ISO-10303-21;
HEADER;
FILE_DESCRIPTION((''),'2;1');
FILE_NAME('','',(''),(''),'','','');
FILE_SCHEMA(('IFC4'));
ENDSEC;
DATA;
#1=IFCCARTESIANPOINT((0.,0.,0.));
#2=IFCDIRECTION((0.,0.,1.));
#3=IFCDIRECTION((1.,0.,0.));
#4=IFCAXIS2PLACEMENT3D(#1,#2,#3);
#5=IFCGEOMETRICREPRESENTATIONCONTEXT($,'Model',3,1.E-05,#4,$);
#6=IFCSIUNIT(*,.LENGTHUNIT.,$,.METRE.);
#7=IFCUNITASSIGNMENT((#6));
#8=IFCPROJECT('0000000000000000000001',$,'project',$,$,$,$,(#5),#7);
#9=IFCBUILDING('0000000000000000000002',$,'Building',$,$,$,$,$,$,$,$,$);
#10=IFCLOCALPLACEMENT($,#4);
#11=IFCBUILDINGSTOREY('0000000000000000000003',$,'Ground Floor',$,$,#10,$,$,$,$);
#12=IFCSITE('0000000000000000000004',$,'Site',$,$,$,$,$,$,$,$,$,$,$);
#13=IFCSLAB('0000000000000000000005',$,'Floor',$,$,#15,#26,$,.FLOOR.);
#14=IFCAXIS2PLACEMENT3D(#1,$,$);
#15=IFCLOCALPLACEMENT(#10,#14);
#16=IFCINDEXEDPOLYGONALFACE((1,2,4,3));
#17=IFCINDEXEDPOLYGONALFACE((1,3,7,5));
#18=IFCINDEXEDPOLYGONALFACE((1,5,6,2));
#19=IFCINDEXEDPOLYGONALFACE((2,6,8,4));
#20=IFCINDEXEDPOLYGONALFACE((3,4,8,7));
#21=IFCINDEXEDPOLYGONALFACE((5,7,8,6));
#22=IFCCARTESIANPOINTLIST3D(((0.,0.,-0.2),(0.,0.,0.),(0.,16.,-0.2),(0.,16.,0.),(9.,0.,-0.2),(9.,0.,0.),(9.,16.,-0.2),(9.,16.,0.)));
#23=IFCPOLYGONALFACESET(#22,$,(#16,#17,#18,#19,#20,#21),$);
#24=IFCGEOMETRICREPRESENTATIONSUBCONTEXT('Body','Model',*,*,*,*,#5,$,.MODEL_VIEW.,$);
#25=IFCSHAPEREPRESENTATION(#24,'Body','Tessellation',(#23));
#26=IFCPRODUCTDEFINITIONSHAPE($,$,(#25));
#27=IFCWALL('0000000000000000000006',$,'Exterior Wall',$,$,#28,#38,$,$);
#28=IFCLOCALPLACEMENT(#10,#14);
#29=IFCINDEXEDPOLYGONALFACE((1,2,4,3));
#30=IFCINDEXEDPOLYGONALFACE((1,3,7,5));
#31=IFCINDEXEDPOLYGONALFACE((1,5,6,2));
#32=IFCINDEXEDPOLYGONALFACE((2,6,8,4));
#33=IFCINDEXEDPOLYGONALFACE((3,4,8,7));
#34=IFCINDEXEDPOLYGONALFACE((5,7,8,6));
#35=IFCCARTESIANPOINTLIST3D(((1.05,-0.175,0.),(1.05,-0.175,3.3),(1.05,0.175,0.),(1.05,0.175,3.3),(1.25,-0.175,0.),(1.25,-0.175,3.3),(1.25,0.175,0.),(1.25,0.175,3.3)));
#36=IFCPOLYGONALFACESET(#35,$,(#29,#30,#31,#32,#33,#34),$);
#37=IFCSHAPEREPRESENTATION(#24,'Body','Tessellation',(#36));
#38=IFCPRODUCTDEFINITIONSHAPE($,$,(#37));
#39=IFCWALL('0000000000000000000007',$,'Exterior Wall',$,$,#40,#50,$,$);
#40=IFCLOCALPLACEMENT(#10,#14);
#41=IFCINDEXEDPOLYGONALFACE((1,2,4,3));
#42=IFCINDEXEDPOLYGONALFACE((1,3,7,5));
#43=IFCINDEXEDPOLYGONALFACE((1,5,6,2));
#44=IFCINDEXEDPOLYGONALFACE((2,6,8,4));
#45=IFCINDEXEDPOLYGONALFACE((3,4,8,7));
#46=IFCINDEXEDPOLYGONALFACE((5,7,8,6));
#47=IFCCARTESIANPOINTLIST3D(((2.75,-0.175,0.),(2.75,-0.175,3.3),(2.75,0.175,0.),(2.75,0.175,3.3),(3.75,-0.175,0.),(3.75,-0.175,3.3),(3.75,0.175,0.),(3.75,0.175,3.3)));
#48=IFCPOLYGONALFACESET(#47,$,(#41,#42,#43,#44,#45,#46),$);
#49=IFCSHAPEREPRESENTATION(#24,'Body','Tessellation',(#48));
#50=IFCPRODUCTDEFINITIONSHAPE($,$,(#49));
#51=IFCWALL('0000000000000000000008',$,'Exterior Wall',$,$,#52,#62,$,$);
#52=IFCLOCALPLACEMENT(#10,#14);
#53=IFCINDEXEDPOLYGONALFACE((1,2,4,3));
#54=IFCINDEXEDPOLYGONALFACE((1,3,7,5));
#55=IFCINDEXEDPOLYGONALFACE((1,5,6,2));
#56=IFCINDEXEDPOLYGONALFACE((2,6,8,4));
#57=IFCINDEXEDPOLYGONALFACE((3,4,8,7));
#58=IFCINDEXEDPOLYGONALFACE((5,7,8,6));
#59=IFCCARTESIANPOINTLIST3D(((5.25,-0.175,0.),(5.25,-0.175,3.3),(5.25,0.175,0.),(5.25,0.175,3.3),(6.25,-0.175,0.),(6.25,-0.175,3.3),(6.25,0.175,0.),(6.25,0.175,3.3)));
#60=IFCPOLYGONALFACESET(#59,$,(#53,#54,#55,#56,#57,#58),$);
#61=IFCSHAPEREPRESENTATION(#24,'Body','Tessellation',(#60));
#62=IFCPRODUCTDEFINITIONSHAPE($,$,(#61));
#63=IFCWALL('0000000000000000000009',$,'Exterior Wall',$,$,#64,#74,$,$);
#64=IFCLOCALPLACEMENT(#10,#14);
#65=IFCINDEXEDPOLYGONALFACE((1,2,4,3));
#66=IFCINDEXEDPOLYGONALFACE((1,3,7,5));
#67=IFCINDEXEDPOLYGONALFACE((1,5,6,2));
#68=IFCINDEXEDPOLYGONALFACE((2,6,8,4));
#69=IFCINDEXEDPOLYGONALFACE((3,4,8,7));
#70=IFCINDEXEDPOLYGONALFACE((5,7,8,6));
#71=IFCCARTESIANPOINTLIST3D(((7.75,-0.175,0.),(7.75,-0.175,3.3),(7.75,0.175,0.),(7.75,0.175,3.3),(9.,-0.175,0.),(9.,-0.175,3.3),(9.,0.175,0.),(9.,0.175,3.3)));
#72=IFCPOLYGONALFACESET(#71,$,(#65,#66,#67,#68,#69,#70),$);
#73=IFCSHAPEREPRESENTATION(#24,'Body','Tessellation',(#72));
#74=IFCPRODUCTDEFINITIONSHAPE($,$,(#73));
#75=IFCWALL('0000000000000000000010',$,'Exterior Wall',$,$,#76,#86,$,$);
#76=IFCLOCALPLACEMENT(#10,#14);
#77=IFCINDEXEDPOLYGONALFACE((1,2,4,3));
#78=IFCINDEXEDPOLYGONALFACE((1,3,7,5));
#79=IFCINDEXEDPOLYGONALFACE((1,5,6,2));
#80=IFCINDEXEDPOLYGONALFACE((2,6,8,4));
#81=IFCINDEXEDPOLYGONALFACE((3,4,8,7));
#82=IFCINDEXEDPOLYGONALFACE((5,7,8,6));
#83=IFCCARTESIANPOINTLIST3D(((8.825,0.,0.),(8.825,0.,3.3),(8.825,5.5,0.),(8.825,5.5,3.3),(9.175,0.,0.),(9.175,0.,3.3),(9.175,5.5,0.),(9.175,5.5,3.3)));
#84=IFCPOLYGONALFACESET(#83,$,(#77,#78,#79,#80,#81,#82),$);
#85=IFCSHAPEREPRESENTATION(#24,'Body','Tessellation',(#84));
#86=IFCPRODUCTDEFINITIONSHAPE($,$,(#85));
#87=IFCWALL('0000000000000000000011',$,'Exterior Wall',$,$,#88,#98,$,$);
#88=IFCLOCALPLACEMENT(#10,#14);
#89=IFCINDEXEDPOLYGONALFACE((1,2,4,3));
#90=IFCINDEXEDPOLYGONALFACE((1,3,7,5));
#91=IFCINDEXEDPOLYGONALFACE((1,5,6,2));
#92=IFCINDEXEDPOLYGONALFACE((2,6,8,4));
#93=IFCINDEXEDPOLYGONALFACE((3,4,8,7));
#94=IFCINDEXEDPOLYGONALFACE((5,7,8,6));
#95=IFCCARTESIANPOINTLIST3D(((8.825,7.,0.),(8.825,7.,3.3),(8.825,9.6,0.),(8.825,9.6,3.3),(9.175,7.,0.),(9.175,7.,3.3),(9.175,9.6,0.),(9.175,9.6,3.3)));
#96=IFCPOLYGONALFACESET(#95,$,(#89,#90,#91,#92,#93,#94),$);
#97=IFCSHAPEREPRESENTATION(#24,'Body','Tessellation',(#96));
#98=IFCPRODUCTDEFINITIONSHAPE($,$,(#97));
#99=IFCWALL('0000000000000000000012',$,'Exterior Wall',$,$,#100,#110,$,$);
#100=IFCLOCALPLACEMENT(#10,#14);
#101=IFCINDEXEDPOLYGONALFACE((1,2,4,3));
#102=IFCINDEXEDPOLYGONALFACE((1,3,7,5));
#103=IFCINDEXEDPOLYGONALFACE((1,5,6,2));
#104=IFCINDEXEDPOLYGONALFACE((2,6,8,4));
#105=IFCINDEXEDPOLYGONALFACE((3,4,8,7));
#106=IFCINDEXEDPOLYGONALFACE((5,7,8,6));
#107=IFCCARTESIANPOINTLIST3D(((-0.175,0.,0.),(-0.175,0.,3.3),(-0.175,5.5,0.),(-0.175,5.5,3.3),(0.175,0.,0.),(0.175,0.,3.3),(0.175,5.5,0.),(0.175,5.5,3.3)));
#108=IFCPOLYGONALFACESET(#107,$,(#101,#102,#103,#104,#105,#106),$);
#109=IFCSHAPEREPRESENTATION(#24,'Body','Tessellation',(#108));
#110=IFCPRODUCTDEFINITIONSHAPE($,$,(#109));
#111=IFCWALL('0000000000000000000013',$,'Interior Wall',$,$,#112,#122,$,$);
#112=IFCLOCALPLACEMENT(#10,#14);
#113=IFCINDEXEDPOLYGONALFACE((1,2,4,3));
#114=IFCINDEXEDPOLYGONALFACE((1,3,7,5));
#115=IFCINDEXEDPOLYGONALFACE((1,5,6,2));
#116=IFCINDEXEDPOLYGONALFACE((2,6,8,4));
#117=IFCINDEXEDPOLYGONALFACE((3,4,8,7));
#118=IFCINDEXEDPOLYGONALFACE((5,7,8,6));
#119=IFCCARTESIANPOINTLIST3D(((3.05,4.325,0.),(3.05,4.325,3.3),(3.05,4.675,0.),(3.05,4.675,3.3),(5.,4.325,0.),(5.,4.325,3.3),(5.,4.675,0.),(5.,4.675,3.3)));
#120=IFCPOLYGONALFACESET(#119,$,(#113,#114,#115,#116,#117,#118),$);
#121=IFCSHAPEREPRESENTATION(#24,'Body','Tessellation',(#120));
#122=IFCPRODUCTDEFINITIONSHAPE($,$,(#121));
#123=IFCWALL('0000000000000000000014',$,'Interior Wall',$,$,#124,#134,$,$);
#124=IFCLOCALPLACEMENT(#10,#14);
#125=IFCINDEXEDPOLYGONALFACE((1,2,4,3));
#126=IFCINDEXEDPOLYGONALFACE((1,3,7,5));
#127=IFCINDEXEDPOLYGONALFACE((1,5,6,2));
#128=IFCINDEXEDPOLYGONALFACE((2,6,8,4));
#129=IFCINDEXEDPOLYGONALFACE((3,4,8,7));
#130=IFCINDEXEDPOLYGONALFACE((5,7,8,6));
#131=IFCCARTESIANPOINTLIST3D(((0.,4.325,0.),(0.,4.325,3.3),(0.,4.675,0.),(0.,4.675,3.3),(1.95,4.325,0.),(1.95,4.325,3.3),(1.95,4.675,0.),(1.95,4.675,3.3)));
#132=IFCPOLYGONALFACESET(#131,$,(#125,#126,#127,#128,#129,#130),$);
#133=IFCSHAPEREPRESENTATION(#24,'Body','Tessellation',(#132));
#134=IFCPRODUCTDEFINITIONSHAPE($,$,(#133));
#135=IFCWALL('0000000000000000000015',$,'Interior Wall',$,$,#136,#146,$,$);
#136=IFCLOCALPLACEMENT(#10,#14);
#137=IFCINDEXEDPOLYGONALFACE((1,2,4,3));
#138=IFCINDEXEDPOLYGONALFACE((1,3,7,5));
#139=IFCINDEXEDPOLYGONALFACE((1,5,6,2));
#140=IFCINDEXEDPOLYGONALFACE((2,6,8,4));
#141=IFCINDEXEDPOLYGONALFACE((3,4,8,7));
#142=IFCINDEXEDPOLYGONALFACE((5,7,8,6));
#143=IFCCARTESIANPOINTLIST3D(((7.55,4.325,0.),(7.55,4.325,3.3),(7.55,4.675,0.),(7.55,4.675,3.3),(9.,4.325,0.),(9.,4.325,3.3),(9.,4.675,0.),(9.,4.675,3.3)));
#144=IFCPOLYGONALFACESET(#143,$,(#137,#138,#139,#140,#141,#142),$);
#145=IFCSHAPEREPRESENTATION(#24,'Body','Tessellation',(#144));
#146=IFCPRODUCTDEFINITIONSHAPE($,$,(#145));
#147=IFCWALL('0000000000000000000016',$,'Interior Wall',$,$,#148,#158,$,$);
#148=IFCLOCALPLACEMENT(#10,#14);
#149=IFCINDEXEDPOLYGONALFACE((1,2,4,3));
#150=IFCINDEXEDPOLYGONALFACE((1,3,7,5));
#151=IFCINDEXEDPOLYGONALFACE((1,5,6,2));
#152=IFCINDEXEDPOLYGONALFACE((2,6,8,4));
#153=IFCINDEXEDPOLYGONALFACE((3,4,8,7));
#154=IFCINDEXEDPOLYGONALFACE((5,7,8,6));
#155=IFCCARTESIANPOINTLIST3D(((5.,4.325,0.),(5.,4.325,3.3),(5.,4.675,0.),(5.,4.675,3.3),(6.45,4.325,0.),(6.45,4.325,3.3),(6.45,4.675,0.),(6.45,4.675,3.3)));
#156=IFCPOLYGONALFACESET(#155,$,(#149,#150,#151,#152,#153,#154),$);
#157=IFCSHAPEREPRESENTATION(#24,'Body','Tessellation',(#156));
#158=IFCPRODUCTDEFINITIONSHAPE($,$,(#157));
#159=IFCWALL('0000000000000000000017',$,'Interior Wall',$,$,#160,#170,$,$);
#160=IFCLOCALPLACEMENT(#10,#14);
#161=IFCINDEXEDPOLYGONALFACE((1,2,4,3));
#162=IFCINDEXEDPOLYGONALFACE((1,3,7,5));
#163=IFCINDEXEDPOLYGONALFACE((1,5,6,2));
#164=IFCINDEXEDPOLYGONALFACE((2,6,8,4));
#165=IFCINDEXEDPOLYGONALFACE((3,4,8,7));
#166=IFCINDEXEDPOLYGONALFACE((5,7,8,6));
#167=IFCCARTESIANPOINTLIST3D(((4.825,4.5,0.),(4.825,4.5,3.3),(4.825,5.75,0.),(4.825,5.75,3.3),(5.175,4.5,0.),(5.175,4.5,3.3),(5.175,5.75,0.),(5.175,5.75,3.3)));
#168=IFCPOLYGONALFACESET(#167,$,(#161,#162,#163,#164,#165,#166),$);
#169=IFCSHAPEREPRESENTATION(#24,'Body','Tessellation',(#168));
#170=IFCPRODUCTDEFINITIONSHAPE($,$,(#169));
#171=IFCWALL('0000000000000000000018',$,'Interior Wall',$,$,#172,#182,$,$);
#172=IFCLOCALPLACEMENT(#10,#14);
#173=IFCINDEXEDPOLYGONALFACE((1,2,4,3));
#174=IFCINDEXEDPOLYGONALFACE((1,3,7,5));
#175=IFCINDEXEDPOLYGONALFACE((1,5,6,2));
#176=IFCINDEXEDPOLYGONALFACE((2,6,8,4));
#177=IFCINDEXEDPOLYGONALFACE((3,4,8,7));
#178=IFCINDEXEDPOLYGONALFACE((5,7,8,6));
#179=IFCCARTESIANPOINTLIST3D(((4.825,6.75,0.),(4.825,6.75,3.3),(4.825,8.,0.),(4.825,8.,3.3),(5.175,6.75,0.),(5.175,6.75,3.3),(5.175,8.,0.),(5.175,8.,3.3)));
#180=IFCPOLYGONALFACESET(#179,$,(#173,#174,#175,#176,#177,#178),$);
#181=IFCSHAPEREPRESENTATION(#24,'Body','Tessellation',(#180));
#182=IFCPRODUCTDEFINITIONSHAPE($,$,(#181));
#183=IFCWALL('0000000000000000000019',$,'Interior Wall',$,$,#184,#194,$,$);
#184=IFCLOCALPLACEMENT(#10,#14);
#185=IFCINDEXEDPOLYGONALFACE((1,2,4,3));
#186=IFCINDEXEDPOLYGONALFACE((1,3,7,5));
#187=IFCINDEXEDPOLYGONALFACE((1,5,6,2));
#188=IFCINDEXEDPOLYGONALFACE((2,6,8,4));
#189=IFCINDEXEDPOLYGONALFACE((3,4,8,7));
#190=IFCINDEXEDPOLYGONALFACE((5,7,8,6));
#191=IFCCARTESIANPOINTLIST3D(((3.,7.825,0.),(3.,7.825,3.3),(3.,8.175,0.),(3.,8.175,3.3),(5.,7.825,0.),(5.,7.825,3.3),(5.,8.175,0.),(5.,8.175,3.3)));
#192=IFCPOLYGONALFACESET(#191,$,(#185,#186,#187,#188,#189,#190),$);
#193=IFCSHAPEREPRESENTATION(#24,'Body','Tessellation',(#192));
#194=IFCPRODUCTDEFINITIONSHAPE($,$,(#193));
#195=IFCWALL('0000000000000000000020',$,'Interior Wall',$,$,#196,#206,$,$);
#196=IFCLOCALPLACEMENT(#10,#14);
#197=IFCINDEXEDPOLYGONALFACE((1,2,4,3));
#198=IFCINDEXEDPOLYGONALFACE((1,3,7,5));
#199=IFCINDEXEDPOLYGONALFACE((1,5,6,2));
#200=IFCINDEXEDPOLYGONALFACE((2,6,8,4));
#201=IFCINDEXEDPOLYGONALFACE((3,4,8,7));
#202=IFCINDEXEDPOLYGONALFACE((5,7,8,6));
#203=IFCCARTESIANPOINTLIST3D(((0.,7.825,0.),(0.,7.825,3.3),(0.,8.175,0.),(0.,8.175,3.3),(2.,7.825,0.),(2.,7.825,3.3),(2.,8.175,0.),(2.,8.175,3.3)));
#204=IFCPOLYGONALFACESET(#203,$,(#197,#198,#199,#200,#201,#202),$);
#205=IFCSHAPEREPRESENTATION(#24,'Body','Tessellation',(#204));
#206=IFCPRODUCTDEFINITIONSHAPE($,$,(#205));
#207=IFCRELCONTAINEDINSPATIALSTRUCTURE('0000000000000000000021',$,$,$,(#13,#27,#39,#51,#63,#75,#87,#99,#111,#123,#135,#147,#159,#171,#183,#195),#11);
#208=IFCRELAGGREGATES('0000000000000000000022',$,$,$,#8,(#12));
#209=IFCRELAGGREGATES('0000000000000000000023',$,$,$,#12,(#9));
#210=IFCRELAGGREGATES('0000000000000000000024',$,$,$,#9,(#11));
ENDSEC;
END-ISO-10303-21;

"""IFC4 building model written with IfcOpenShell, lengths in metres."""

from ifc_helpers import new_model, si_unit, frame, origin_with_axes, place, context, subcontext, project, spatial, indexed_curve, outline, extrude, element, save


model = new_model("IFC4")

# Units and contexts
model_context = context("Model", 3, precision=1e-05, world=origin_with_axes())
body_context = subcontext(model_context, "Body", "Model", "MODEL_VIEW")
ifc_project = project(units=[si_unit("LENGTHUNIT", "METRE")], contexts=[model_context])

# Site, building, storey
site = spatial("IfcSite", under=ifc_project, Name="Site")
building = spatial("IfcBuilding", under=site, Name="Building")
storey_placement = place(None, origin_with_axes())
storey = spatial("IfcBuildingStorey", under=building, at=storey_placement, Name="Ground Floor")

# Slab
slab_placement = place(storey_placement, frame((0.0, 0.0, -0.2), z_axis=(0.0, 0.0, 1.0), x_axis=(1.0, 0.0, 0.0)))
element("IfcSlab", 1, at=slab_placement, inside=storey, Name="Floor", PredefinedType="FLOOR", context=body_context, shape_type="SweptSolid", body=[
    extrude(outline(indexed_curve([(0.0, 0.0), (9.0, 0.0), (9.0, 16.0), (0.0, 16.0)])), None, (0.0, 0.0, 1.0), 0.2),
])

# Walls
wall_1_placement = place(storey_placement, frame((1.05, 0.0, 0.0), z_axis=(0.0, 0.0, 1.0), x_axis=(1.0, 0.0, 0.0)))
element("IfcWall", 2, at=wall_1_placement, inside=storey, Name="Exterior Wall", context=body_context, shape_type="SweptSolid", body=[
    extrude(outline(indexed_curve([(0.0, 0.0), (0.0, 0.35), (0.2, 0.35), (0.2, 0.0), (0.0, 0.0)], self_intersect=False)), frame((0.0, -0.175, 0.0), z_axis=(0.0, 0.0, 1.0), x_axis=(1.0, 0.0, 0.0)), (0.0, 0.0, 1.0), 3.3),
])
for number, where, z_axis, x_axis, name in (
    (3, (2.75, 0.0, 0.0), (0.0, 0.0, 1.0), (1.0, 0.0, 0.0), "Exterior Wall"),
    (4, (5.25, 0.0, 0.0), (0.0, 0.0, 1.0), (1.0, 0.0, 0.0), "Exterior Wall"),
):
    element("IfcWall", number, at=place(storey_placement, frame(where, z_axis=z_axis, x_axis=x_axis)), inside=storey, Name=name, context=body_context, shape_type="SweptSolid", body=[
        extrude(outline(indexed_curve([(0.0, 0.0), (0.0, 0.35), (1.0, 0.35), (1.0, 0.0), (0.0, 0.0)], self_intersect=False)), frame((0.0, -0.175, 0.0), z_axis=(0.0, 0.0, 1.0), x_axis=(1.0, 0.0, 0.0)), (0.0, 0.0, 1.0), 3.3),
    ])
wall_2_placement = place(storey_placement, frame((7.75, 0.0, 0.0), z_axis=(0.0, 0.0, 1.0), x_axis=(1.0, 0.0, 0.0)))
element("IfcWall", 5, at=wall_2_placement, inside=storey, Name="Exterior Wall", context=body_context, shape_type="SweptSolid", body=[
    extrude(outline(indexed_curve([(0.0, 0.0), (0.0, 0.35), (1.25, 0.35), (1.25, 0.0), (0.0, 0.0)], self_intersect=False)), frame((0.0, -0.175, 0.0), z_axis=(0.0, 0.0, 1.0), x_axis=(1.0, 0.0, 0.0)), (0.0, 0.0, 1.0), 3.3),
])
wall_3_placement = place(storey_placement, frame((9.0, 0.0, 0.0), z_axis=(0.0, 0.0, 1.0), x_axis=(0.0, 1.0, 0.0)))
element("IfcWall", 6, at=wall_3_placement, inside=storey, Name="Exterior Wall", context=body_context, shape_type="SweptSolid", body=[
    extrude(outline(indexed_curve([(0.0, 0.0), (0.0, 0.35), (5.5, 0.35), (5.5, 0.0), (0.0, 0.0)], self_intersect=False)), frame((0.0, -0.175, 0.0), z_axis=(0.0, 0.0, 1.0), x_axis=(1.0, 0.0, 0.0)), (0.0, 0.0, 1.0), 3.3),
])
wall_4_placement = place(storey_placement, frame((9.0, 7.0, 0.0), z_axis=(0.0, 0.0, 1.0), x_axis=(0.0, 1.0, 0.0)))
element("IfcWall", 7, at=wall_4_placement, inside=storey, Name="Exterior Wall", context=body_context, shape_type="SweptSolid", body=[
    extrude(outline(indexed_curve([(0.0, 0.0), (0.0, 0.35), (2.6, 0.35), (2.6, 0.0), (0.0, 0.0)], self_intersect=False)), frame((0.0, -0.175, 0.0), z_axis=(0.0, 0.0, 1.0), x_axis=(1.0, 0.0, 0.0)), (0.0, 0.0, 1.0), 3.3),
])
wall_5_placement = place(storey_placement, frame((0.0, 5.5, 0.0), z_axis=(0.0, 0.0, 1.0), x_axis=(0.0, -1.0, 0.0)))
element("IfcWall", 8, at=wall_5_placement, inside=storey, Name="Exterior Wall", context=body_context, shape_type="SweptSolid", body=[
    extrude(outline(indexed_curve([(0.0, 0.0), (0.0, 0.35), (5.5, 0.35), (5.5, 0.0), (0.0, 0.0)], self_intersect=False)), frame((0.0, -0.175, 0.0), z_axis=(0.0, 0.0, 1.0), x_axis=(1.0, 0.0, 0.0)), (0.0, 0.0, 1.0), 3.3),
])
for number, where, z_axis, x_axis, name in (
    (9, (5.0, 4.5, 0.0), (0.0, 0.0, 1.0), (-1.0, 0.0, 0.0), "Interior Wall"),
    (10, (1.95, 4.5, 0.0), (0.0, 0.0, 1.0), (-1.0, 0.0, 0.0), "Interior Wall"),
):
    element("IfcWall", number, at=place(storey_placement, frame(where, z_axis=z_axis, x_axis=x_axis)), inside=storey, Name=name, context=body_context, shape_type="SweptSolid", body=[
        extrude(outline(indexed_curve([(0.0, 0.0), (0.0, 0.35), (1.95, 0.35), (1.95, 0.0), (0.0, 0.0)], self_intersect=False)), frame((0.0, -0.175, 0.0), z_axis=(0.0, 0.0, 1.0), x_axis=(1.0, 0.0, 0.0)), (0.0, 0.0, 1.0), 3.3),
    ])
for number, where, z_axis, x_axis, name in (
    (11, (9.0, 4.5, 0.0), (0.0, 0.0, 1.0), (-1.0, 0.0, 0.0), "Interior Wall"),
    (12, (6.45, 4.5, 0.0), (0.0, 0.0, 1.0), (-1.0, 0.0, 0.0), "Interior Wall"),
):
    element("IfcWall", number, at=place(storey_placement, frame(where, z_axis=z_axis, x_axis=x_axis)), inside=storey, Name=name, context=body_context, shape_type="SweptSolid", body=[
        extrude(outline(indexed_curve([(0.0, 0.0), (0.0, 0.35), (1.45, 0.35), (1.45, 0.0), (0.0, 0.0)], self_intersect=False)), frame((0.0, -0.175, 0.0), z_axis=(0.0, 0.0, 1.0), x_axis=(1.0, 0.0, 0.0)), (0.0, 0.0, 1.0), 3.3),
    ])
for number, where, z_axis, x_axis, name in (
    (13, (5.0, 4.5, 0.0), (0.0, 0.0, 1.0), (0.0, 1.0, 0.0), "Interior Wall"),
    (14, (5.0, 6.75, 0.0), (0.0, 0.0, 1.0), (0.0, 1.0, 0.0), "Interior Wall"),
):
    element("IfcWall", number, at=place(storey_placement, frame(where, z_axis=z_axis, x_axis=x_axis)), inside=storey, Name=name, context=body_context, shape_type="SweptSolid", body=[
        extrude(outline(indexed_curve([(0.0, 0.0), (0.0, 0.35), (1.25, 0.35), (1.25, 0.0), (0.0, 0.0)], self_intersect=False)), frame((0.0, -0.175, 0.0), z_axis=(0.0, 0.0, 1.0), x_axis=(1.0, 0.0, 0.0)), (0.0, 0.0, 1.0), 3.3),
    ])
for number, where, z_axis, x_axis, name in (
    (15, (5.0, 8.0, 0.0), (0.0, 0.0, 1.0), (-1.0, 0.0, 0.0), "Interior Wall"),
    (16, (2.0, 8.0, 0.0), (0.0, 0.0, 1.0), (-1.0, 0.0, 0.0), "Interior Wall"),
):
    element("IfcWall", number, at=place(storey_placement, frame(where, z_axis=z_axis, x_axis=x_axis)), inside=storey, Name=name, context=body_context, shape_type="SweptSolid", body=[
        extrude(outline(indexed_curve([(0.0, 0.0), (0.0, 0.35), (2.0, 0.35), (2.0, 0.0), (0.0, 0.0)], self_intersect=False)), frame((0.0, -0.175, 0.0), z_axis=(0.0, 0.0, 1.0), x_axis=(1.0, 0.0, 0.0)), (0.0, 0.0, 1.0), 3.3),
    ])

save(model, "model.ifc")
